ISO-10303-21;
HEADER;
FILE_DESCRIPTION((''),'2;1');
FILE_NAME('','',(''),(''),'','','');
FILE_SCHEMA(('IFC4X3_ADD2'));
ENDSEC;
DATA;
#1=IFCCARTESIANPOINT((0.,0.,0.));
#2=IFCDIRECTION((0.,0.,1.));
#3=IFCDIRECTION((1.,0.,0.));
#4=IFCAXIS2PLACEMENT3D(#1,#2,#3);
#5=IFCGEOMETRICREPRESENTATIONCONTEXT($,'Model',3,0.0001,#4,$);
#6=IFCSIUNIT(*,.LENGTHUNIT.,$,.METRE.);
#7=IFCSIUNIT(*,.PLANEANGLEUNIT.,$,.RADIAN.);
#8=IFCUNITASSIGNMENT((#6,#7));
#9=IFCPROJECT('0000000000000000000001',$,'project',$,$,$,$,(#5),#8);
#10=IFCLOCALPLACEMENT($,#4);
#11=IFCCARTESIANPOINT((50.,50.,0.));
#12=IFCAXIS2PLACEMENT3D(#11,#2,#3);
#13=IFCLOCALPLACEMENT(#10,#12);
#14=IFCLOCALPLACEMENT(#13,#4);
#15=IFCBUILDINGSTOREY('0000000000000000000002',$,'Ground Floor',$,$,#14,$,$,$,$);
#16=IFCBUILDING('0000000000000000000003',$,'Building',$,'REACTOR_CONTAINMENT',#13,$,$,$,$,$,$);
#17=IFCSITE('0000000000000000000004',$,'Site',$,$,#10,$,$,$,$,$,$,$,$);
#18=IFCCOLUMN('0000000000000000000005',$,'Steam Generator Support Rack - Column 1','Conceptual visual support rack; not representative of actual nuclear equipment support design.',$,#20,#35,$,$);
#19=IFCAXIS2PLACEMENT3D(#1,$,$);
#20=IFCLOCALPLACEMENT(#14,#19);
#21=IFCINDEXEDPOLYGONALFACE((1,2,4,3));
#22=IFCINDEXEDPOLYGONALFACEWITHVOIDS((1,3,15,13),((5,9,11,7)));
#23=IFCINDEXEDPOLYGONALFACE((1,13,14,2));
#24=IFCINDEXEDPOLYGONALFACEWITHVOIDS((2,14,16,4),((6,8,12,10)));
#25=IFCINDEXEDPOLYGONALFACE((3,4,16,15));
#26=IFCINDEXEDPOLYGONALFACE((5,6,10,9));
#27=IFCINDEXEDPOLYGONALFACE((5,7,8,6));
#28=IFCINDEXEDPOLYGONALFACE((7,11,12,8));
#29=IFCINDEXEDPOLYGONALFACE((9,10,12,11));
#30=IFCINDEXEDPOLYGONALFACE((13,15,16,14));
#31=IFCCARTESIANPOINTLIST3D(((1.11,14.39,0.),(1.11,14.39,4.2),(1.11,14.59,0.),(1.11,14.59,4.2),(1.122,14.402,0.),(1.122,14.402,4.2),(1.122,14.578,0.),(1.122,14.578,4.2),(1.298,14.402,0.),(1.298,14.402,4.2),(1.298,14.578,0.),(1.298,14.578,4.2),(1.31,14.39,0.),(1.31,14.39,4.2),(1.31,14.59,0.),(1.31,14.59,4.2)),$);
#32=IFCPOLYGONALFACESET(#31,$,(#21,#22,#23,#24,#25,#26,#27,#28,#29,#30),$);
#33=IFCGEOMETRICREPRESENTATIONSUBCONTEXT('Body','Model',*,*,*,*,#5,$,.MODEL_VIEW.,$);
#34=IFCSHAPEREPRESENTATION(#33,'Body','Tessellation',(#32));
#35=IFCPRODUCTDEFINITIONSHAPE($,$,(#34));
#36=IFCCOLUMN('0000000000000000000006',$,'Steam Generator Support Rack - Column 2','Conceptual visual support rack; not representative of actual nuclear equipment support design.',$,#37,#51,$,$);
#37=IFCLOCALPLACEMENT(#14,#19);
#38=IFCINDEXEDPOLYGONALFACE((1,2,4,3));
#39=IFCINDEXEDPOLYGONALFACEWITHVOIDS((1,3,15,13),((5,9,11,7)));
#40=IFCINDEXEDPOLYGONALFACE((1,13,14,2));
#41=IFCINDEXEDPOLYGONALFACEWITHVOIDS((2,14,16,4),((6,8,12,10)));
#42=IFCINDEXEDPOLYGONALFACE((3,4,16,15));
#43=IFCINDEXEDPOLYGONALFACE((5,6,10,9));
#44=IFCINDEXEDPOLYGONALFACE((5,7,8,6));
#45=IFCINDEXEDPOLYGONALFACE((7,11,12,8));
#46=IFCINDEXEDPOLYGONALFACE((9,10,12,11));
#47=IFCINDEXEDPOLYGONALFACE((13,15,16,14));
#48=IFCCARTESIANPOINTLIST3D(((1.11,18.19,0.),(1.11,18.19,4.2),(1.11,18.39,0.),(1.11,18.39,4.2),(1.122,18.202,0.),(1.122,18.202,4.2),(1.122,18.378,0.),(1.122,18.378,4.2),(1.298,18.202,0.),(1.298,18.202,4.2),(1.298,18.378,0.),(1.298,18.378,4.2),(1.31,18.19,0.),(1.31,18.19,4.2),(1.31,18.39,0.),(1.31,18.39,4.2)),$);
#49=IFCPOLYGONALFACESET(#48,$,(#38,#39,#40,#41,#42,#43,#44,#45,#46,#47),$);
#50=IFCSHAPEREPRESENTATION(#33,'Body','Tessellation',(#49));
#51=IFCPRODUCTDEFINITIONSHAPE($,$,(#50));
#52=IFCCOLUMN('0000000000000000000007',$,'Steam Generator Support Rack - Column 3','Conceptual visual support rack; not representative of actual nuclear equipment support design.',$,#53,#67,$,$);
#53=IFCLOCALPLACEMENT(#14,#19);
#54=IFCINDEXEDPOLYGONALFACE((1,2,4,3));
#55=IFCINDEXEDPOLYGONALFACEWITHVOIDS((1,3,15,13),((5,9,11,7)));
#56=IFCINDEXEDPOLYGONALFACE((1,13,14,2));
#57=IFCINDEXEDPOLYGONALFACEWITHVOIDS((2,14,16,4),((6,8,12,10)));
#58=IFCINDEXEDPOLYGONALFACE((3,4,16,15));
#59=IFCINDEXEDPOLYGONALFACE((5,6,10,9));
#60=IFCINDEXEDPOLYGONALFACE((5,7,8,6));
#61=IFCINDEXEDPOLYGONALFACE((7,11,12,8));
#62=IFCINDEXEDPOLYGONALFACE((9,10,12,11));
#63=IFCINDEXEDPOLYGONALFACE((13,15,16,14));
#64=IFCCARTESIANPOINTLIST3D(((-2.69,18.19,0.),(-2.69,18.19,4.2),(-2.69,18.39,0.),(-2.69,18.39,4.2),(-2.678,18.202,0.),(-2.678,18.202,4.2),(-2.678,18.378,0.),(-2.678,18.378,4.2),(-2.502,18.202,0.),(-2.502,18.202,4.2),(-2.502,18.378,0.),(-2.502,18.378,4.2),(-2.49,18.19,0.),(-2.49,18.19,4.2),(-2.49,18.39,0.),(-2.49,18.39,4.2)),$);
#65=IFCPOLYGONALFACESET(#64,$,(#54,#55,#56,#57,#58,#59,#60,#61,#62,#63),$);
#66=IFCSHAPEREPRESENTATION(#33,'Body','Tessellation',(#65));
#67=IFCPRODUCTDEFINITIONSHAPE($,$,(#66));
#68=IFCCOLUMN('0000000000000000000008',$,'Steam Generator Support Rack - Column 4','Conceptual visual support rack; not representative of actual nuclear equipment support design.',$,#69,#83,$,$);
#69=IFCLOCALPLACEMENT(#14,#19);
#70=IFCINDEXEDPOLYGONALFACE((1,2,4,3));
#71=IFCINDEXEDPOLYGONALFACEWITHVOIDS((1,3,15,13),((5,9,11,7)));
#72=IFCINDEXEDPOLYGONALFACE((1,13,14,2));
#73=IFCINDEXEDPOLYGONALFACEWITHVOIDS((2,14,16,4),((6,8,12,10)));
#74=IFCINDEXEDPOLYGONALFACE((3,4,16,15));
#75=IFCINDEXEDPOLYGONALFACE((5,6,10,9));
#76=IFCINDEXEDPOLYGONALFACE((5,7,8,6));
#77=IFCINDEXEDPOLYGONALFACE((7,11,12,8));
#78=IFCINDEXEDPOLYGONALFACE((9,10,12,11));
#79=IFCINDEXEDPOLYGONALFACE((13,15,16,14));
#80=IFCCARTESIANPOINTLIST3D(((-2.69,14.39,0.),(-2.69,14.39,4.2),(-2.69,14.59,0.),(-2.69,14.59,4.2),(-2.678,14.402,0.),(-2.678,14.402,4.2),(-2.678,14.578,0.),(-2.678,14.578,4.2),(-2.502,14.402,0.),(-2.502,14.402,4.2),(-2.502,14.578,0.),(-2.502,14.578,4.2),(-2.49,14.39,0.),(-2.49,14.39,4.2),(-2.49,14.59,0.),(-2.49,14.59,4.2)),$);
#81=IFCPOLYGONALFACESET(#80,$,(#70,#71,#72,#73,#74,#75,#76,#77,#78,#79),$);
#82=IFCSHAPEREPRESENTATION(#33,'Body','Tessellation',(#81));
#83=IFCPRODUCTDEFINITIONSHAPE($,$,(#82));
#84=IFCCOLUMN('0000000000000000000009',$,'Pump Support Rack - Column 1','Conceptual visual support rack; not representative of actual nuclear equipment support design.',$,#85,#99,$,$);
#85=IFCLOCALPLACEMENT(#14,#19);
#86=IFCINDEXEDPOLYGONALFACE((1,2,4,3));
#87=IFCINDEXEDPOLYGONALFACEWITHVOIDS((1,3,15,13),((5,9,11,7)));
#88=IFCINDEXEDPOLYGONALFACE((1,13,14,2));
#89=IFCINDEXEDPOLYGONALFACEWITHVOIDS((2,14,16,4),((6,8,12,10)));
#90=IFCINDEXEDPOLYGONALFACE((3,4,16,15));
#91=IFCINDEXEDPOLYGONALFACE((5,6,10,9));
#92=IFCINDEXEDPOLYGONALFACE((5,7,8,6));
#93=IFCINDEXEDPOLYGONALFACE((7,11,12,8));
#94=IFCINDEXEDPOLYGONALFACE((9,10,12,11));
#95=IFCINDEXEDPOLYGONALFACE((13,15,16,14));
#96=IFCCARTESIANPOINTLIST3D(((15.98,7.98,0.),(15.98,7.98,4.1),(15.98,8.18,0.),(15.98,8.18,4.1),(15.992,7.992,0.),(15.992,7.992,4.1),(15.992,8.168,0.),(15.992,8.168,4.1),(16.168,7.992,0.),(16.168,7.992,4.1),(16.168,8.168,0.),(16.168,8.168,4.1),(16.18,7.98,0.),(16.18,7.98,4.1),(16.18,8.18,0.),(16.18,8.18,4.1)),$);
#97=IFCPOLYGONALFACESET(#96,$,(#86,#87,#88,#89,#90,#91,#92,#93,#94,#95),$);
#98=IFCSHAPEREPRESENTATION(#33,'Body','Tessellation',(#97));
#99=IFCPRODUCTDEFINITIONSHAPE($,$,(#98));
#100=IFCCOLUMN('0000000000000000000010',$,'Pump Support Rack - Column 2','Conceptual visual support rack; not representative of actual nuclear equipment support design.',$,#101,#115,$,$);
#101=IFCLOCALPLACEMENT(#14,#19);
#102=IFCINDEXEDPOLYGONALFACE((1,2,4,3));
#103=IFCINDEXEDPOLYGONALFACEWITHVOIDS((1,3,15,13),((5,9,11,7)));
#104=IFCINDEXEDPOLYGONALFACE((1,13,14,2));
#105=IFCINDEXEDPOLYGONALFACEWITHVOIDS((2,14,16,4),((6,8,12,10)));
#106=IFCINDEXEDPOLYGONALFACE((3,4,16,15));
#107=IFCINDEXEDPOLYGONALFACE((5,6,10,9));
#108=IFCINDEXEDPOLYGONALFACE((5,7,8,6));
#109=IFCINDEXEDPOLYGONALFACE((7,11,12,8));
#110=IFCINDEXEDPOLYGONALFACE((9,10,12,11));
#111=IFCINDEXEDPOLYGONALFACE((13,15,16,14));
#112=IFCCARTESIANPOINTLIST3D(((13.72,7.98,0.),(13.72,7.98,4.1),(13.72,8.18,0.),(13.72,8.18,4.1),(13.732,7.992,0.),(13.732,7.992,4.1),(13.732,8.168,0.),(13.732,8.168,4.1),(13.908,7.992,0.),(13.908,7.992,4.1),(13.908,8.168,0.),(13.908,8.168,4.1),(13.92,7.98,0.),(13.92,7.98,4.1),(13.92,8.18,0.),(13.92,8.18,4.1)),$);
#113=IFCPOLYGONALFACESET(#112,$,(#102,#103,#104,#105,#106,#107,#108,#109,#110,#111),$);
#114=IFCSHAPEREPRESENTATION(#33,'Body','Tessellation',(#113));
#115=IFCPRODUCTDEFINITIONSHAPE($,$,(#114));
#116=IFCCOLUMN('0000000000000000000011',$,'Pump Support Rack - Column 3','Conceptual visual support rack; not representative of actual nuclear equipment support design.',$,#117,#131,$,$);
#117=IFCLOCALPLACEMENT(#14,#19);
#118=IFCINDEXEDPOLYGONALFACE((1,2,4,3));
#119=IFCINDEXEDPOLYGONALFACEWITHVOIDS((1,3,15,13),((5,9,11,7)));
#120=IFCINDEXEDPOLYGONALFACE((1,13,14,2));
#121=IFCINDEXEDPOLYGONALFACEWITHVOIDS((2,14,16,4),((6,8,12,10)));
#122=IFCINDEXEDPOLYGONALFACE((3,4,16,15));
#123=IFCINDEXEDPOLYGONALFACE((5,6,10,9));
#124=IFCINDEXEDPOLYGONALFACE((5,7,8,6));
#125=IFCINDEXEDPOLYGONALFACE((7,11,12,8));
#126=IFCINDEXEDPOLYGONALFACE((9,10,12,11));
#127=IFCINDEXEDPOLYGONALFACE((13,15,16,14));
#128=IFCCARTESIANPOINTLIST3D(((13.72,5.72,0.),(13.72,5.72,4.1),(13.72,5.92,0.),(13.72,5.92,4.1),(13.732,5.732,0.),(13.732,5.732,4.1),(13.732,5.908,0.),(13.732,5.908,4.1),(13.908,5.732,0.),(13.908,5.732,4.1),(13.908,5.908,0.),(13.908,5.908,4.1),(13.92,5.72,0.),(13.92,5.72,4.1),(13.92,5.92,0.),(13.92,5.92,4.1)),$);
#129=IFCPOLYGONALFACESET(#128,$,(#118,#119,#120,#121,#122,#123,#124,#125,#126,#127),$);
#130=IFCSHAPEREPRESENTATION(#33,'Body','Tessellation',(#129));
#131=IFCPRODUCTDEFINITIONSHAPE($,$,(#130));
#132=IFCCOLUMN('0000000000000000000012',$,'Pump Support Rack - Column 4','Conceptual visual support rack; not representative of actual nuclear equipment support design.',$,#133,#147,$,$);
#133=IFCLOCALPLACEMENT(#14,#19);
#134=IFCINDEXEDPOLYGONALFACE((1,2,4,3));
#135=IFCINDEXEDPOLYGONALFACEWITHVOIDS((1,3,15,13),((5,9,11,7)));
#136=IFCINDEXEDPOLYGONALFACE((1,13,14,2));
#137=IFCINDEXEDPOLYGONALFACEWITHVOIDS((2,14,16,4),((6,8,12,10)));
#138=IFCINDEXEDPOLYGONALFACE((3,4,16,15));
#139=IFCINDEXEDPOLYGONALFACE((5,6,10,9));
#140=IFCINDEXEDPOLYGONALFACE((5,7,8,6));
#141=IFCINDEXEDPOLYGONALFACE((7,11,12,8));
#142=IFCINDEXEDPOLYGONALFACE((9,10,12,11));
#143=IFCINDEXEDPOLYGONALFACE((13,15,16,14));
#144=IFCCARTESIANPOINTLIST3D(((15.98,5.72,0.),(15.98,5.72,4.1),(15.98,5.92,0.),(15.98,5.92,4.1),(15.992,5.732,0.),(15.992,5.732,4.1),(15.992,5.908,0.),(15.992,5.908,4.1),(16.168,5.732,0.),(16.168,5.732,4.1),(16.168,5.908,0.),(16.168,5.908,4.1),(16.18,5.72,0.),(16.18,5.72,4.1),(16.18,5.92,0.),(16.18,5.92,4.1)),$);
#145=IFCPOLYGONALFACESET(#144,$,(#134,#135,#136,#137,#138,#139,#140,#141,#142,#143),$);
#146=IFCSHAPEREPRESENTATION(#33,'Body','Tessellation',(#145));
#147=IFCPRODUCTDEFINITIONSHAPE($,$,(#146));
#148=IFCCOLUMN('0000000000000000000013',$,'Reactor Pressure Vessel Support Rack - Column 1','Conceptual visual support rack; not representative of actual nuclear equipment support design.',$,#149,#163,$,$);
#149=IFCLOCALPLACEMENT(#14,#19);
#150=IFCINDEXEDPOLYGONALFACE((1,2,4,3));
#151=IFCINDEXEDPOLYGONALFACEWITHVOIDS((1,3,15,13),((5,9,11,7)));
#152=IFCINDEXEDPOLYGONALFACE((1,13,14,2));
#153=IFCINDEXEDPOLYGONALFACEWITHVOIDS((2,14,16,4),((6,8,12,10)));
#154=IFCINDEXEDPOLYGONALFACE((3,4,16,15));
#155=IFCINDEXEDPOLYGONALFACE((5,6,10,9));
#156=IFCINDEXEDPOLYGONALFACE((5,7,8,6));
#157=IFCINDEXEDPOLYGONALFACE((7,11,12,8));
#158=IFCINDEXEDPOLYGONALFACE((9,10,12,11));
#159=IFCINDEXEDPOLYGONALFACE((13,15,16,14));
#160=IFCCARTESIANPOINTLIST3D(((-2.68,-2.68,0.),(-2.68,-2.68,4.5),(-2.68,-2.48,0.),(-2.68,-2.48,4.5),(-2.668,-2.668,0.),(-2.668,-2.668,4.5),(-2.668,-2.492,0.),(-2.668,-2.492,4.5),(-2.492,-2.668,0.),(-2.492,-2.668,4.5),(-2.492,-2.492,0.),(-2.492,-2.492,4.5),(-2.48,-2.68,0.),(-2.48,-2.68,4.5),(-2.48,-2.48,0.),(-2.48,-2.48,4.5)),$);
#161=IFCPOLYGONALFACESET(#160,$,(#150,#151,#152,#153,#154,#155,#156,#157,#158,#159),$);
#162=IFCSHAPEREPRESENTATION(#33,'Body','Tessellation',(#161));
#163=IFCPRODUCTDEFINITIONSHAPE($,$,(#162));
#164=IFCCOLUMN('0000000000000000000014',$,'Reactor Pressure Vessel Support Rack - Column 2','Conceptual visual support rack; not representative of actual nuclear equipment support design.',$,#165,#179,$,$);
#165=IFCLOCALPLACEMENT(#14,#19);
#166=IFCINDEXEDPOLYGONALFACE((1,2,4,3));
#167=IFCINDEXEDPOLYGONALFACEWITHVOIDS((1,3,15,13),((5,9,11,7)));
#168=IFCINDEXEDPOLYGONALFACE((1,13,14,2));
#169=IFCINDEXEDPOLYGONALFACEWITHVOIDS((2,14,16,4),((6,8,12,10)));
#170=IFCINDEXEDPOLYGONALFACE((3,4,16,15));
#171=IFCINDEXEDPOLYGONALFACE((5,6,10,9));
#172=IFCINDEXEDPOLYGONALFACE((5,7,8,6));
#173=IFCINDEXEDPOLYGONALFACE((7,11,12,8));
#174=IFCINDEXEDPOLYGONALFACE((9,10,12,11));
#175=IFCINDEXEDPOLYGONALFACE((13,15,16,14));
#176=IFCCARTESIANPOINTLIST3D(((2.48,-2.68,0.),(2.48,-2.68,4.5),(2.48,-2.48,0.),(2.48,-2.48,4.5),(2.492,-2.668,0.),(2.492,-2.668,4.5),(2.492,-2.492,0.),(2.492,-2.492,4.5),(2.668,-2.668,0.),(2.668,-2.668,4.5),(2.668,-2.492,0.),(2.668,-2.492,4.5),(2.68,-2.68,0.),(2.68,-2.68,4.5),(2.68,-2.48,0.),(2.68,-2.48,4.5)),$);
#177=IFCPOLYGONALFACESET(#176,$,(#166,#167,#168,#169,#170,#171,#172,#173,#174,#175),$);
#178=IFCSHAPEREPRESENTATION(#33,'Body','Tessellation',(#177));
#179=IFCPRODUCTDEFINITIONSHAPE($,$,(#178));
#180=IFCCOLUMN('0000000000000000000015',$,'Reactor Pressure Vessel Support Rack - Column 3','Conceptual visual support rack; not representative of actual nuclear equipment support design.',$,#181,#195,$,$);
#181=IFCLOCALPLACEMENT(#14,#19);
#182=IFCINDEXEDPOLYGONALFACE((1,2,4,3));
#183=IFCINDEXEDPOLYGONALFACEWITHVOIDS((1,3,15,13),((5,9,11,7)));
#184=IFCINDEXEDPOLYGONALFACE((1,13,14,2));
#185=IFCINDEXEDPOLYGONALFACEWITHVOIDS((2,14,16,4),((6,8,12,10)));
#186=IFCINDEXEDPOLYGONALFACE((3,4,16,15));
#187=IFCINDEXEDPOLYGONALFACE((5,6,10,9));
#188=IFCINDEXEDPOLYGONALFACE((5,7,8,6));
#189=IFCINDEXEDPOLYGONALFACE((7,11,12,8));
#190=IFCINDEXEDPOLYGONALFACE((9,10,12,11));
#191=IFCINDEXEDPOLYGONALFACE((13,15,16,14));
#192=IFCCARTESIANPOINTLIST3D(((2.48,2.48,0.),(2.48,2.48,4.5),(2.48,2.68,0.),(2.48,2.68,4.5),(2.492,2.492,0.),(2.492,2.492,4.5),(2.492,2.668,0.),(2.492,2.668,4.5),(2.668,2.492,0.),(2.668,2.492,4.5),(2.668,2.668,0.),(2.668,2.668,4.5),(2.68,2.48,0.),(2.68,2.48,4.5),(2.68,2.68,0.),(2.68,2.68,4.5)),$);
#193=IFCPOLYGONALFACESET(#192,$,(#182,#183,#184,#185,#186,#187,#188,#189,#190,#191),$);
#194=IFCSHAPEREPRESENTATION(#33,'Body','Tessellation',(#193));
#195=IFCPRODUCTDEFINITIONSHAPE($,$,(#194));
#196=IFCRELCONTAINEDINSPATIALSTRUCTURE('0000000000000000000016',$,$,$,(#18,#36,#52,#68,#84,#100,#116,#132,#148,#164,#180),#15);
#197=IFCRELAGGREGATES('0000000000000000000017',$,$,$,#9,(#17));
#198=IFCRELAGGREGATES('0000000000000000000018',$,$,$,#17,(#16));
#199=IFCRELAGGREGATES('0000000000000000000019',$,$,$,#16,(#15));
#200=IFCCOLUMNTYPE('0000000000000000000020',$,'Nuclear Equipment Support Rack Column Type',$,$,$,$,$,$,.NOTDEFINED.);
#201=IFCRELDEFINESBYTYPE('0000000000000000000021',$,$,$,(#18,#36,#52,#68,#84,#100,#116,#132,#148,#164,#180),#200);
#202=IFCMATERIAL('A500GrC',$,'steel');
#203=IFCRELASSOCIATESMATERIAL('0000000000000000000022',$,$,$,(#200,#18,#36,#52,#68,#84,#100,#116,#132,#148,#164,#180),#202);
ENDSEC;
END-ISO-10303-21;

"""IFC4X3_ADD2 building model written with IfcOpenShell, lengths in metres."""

from ifc_helpers import new_model, si_unit, frame, origin_with_axes, place, context, subcontext, project, spatial, hollow_rectangle, extrude, material, material_profile, profile_set, profile_usage, type_object, element, save


model = new_model("IFC4X3_ADD2")

# Units and contexts
model_context = context("Model", 3, precision=0.0001, world=origin_with_axes())
body_context = subcontext(model_context, "Body", "Model", "MODEL_VIEW")
ifc_project = project(units=[si_unit("LENGTHUNIT", "METRE"), si_unit("PLANEANGLEUNIT", "RADIAN")], contexts=[model_context])

# Site, building, storey
site_placement = place(None, origin_with_axes())
site = spatial("IfcSite", under=ifc_project, at=site_placement, Name="Site")
building_placement = place(site_placement, frame((50.0, 50.0, 0.0), z_axis=(0.0, 0.0, 1.0), x_axis=(1.0, 0.0, 0.0)))
building = spatial("IfcBuilding", under=site, at=building_placement, Name="Building", ObjectType="REACTOR_CONTAINMENT")
storey_placement = place(building_placement, origin_with_axes())
storey = spatial("IfcBuildingStorey", under=building, at=storey_placement, Name="Ground Floor")

# Columns
ifc_material = material(Name="A500GrC", Category="steel")
ifc_material_profile = material_profile(ifc_material, hollow_rectangle(XDim=0.2, YDim=0.2, WallThickness=0.012))
ifc_profile_set = profile_set([ifc_material_profile], Name="A500GrC steel Nuclear Equipment Support Rack HSS")
ifc_profile_usage_1 = profile_usage(ifc_profile_set, cardinal=5)
column_type = type_object("IfcColumnType", Name="Nuclear Equipment Support Rack Column Type", PredefinedType="NOTDEFINED", material=ifc_profile_set)
column_1_placement = place(None, frame((51.21, 64.49, 0.0), z_axis=(0.0, 0.0, 1.0), x_axis=(0.0, -1.0, 0.0)))
element("IfcColumn", 1, at=column_1_placement, inside=storey, type_object=column_type, material=ifc_profile_usage_1, Name="Steam Generator Support Rack - Column 1", Description="Conceptual visual support rack; not representative of actual nuclear equipment support design.", context=body_context, shape_type="SweptSolid", body=[
    extrude(hollow_rectangle(XDim=0.2, YDim=0.2, WallThickness=0.012), origin_with_axes(), (0.0, 0.0, 1.0), 4.2),
])
ifc_profile_usage_2 = profile_usage(ifc_profile_set, cardinal=5)
column_2_placement = place(None, frame((51.21, 68.29, 0.0), z_axis=(0.0, 0.0, 1.0), x_axis=(0.0, -1.0, 0.0)))
element("IfcColumn", 2, at=column_2_placement, inside=storey, type_object=column_type, material=ifc_profile_usage_2, Name="Steam Generator Support Rack - Column 2", Description="Conceptual visual support rack; not representative of actual nuclear equipment support design.", context=body_context, shape_type="SweptSolid", body=[
    extrude(hollow_rectangle(XDim=0.2, YDim=0.2, WallThickness=0.012), origin_with_axes(), (0.0, 0.0, 1.0), 4.2),
])
ifc_profile_usage_3 = profile_usage(ifc_profile_set, cardinal=5)
column_3_placement = place(None, frame((47.41, 68.29, 0.0), z_axis=(0.0, 0.0, 1.0), x_axis=(0.0, -1.0, 0.0)))
element("IfcColumn", 3, at=column_3_placement, inside=storey, type_object=column_type, material=ifc_profile_usage_3, Name="Steam Generator Support Rack - Column 3", Description="Conceptual visual support rack; not representative of actual nuclear equipment support design.", context=body_context, shape_type="SweptSolid", body=[
    extrude(hollow_rectangle(XDim=0.2, YDim=0.2, WallThickness=0.012), origin_with_axes(), (0.0, 0.0, 1.0), 4.2),
])
ifc_profile_usage_4 = profile_usage(ifc_profile_set, cardinal=5)
column_4_placement = place(None, frame((47.41, 64.49, 0.0), z_axis=(0.0, 0.0, 1.0), x_axis=(0.0, -1.0, 0.0)))
element("IfcColumn", 4, at=column_4_placement, inside=storey, type_object=column_type, material=ifc_profile_usage_4, Name="Steam Generator Support Rack - Column 4", Description="Conceptual visual support rack; not representative of actual nuclear equipment support design.", context=body_context, shape_type="SweptSolid", body=[
    extrude(hollow_rectangle(XDim=0.2, YDim=0.2, WallThickness=0.012), origin_with_axes(), (0.0, 0.0, 1.0), 4.2),
])
ifc_profile_usage_5 = profile_usage(ifc_profile_set, cardinal=5)
column_5_placement = place(None, frame((66.08, 58.08, 0.0), z_axis=(0.0, 0.0, 1.0), x_axis=(0.0, -1.0, 0.0)))
element("IfcColumn", 5, at=column_5_placement, inside=storey, type_object=column_type, material=ifc_profile_usage_5, Name="Pump Support Rack - Column 1", Description="Conceptual visual support rack; not representative of actual nuclear equipment support design.", context=body_context, shape_type="SweptSolid", body=[
    extrude(hollow_rectangle(XDim=0.2, YDim=0.2, WallThickness=0.012), origin_with_axes(), (0.0, 0.0, 1.0), 4.1),
])
ifc_profile_usage_6 = profile_usage(ifc_profile_set, cardinal=5)
column_6_placement = place(None, frame((63.82, 58.08, 0.0), z_axis=(0.0, 0.0, 1.0), x_axis=(0.0, -1.0, 0.0)))
element("IfcColumn", 6, at=column_6_placement, inside=storey, type_object=column_type, material=ifc_profile_usage_6, Name="Pump Support Rack - Column 2", Description="Conceptual visual support rack; not representative of actual nuclear equipment support design.", context=body_context, shape_type="SweptSolid", body=[
    extrude(hollow_rectangle(XDim=0.2, YDim=0.2, WallThickness=0.012), origin_with_axes(), (0.0, 0.0, 1.0), 4.1),
])
ifc_profile_usage_7 = profile_usage(ifc_profile_set, cardinal=5)
column_7_placement = place(None, frame((63.82, 55.82, 0.0), z_axis=(0.0, 0.0, 1.0), x_axis=(0.0, -1.0, 0.0)))
element("IfcColumn", 7, at=column_7_placement, inside=storey, type_object=column_type, material=ifc_profile_usage_7, Name="Pump Support Rack - Column 3", Description="Conceptual visual support rack; not representative of actual nuclear equipment support design.", context=body_context, shape_type="SweptSolid", body=[
    extrude(hollow_rectangle(XDim=0.2, YDim=0.2, WallThickness=0.012), origin_with_axes(), (0.0, 0.0, 1.0), 4.1),
])
ifc_profile_usage_8 = profile_usage(ifc_profile_set, cardinal=5)
column_8_placement = place(None, frame((66.08, 55.82, 0.0), z_axis=(0.0, 0.0, 1.0), x_axis=(0.0, -1.0, 0.0)))
element("IfcColumn", 8, at=column_8_placement, inside=storey, type_object=column_type, material=ifc_profile_usage_8, Name="Pump Support Rack - Column 4", Description="Conceptual visual support rack; not representative of actual nuclear equipment support design.", context=body_context, shape_type="SweptSolid", body=[
    extrude(hollow_rectangle(XDim=0.2, YDim=0.2, WallThickness=0.012), origin_with_axes(), (0.0, 0.0, 1.0), 4.1),
])
ifc_profile_usage_9 = profile_usage(ifc_profile_set, cardinal=5)
column_9_placement = place(None, frame((47.42, 47.42, 0.0), z_axis=(0.0, 0.0, 1.0), x_axis=(0.0, -1.0, 0.0)))
element("IfcColumn", 9, at=column_9_placement, inside=storey, type_object=column_type, material=ifc_profile_usage_9, Name="Reactor Pressure Vessel Support Rack - Column 1", Description="Conceptual visual support rack; not representative of actual nuclear equipment support design.", context=body_context, shape_type="SweptSolid", body=[
    extrude(hollow_rectangle(XDim=0.2, YDim=0.2, WallThickness=0.012), origin_with_axes(), (0.0, 0.0, 1.0), 4.5),
])
ifc_profile_usage_10 = profile_usage(ifc_profile_set, cardinal=5)
column_10_placement = place(None, frame((52.58, 47.42, 0.0), z_axis=(0.0, 0.0, 1.0), x_axis=(0.0, -1.0, 0.0)))
element("IfcColumn", 10, at=column_10_placement, inside=storey, type_object=column_type, material=ifc_profile_usage_10, Name="Reactor Pressure Vessel Support Rack - Column 2", Description="Conceptual visual support rack; not representative of actual nuclear equipment support design.", context=body_context, shape_type="SweptSolid", body=[
    extrude(hollow_rectangle(XDim=0.2, YDim=0.2, WallThickness=0.012), origin_with_axes(), (0.0, 0.0, 1.0), 4.5),
])
ifc_profile_usage_11 = profile_usage(ifc_profile_set, cardinal=5)
column_11_placement = place(None, frame((52.58, 52.58, 0.0), z_axis=(0.0, 0.0, 1.0), x_axis=(0.0, -1.0, 0.0)))
element("IfcColumn", 11, at=column_11_placement, inside=storey, type_object=column_type, material=ifc_profile_usage_11, Name="Reactor Pressure Vessel Support Rack - Column 3", Description="Conceptual visual support rack; not representative of actual nuclear equipment support design.", context=body_context, shape_type="SweptSolid", body=[
    extrude(hollow_rectangle(XDim=0.2, YDim=0.2, WallThickness=0.012), origin_with_axes(), (0.0, 0.0, 1.0), 4.5),
])

save(model, "model.ifc")
